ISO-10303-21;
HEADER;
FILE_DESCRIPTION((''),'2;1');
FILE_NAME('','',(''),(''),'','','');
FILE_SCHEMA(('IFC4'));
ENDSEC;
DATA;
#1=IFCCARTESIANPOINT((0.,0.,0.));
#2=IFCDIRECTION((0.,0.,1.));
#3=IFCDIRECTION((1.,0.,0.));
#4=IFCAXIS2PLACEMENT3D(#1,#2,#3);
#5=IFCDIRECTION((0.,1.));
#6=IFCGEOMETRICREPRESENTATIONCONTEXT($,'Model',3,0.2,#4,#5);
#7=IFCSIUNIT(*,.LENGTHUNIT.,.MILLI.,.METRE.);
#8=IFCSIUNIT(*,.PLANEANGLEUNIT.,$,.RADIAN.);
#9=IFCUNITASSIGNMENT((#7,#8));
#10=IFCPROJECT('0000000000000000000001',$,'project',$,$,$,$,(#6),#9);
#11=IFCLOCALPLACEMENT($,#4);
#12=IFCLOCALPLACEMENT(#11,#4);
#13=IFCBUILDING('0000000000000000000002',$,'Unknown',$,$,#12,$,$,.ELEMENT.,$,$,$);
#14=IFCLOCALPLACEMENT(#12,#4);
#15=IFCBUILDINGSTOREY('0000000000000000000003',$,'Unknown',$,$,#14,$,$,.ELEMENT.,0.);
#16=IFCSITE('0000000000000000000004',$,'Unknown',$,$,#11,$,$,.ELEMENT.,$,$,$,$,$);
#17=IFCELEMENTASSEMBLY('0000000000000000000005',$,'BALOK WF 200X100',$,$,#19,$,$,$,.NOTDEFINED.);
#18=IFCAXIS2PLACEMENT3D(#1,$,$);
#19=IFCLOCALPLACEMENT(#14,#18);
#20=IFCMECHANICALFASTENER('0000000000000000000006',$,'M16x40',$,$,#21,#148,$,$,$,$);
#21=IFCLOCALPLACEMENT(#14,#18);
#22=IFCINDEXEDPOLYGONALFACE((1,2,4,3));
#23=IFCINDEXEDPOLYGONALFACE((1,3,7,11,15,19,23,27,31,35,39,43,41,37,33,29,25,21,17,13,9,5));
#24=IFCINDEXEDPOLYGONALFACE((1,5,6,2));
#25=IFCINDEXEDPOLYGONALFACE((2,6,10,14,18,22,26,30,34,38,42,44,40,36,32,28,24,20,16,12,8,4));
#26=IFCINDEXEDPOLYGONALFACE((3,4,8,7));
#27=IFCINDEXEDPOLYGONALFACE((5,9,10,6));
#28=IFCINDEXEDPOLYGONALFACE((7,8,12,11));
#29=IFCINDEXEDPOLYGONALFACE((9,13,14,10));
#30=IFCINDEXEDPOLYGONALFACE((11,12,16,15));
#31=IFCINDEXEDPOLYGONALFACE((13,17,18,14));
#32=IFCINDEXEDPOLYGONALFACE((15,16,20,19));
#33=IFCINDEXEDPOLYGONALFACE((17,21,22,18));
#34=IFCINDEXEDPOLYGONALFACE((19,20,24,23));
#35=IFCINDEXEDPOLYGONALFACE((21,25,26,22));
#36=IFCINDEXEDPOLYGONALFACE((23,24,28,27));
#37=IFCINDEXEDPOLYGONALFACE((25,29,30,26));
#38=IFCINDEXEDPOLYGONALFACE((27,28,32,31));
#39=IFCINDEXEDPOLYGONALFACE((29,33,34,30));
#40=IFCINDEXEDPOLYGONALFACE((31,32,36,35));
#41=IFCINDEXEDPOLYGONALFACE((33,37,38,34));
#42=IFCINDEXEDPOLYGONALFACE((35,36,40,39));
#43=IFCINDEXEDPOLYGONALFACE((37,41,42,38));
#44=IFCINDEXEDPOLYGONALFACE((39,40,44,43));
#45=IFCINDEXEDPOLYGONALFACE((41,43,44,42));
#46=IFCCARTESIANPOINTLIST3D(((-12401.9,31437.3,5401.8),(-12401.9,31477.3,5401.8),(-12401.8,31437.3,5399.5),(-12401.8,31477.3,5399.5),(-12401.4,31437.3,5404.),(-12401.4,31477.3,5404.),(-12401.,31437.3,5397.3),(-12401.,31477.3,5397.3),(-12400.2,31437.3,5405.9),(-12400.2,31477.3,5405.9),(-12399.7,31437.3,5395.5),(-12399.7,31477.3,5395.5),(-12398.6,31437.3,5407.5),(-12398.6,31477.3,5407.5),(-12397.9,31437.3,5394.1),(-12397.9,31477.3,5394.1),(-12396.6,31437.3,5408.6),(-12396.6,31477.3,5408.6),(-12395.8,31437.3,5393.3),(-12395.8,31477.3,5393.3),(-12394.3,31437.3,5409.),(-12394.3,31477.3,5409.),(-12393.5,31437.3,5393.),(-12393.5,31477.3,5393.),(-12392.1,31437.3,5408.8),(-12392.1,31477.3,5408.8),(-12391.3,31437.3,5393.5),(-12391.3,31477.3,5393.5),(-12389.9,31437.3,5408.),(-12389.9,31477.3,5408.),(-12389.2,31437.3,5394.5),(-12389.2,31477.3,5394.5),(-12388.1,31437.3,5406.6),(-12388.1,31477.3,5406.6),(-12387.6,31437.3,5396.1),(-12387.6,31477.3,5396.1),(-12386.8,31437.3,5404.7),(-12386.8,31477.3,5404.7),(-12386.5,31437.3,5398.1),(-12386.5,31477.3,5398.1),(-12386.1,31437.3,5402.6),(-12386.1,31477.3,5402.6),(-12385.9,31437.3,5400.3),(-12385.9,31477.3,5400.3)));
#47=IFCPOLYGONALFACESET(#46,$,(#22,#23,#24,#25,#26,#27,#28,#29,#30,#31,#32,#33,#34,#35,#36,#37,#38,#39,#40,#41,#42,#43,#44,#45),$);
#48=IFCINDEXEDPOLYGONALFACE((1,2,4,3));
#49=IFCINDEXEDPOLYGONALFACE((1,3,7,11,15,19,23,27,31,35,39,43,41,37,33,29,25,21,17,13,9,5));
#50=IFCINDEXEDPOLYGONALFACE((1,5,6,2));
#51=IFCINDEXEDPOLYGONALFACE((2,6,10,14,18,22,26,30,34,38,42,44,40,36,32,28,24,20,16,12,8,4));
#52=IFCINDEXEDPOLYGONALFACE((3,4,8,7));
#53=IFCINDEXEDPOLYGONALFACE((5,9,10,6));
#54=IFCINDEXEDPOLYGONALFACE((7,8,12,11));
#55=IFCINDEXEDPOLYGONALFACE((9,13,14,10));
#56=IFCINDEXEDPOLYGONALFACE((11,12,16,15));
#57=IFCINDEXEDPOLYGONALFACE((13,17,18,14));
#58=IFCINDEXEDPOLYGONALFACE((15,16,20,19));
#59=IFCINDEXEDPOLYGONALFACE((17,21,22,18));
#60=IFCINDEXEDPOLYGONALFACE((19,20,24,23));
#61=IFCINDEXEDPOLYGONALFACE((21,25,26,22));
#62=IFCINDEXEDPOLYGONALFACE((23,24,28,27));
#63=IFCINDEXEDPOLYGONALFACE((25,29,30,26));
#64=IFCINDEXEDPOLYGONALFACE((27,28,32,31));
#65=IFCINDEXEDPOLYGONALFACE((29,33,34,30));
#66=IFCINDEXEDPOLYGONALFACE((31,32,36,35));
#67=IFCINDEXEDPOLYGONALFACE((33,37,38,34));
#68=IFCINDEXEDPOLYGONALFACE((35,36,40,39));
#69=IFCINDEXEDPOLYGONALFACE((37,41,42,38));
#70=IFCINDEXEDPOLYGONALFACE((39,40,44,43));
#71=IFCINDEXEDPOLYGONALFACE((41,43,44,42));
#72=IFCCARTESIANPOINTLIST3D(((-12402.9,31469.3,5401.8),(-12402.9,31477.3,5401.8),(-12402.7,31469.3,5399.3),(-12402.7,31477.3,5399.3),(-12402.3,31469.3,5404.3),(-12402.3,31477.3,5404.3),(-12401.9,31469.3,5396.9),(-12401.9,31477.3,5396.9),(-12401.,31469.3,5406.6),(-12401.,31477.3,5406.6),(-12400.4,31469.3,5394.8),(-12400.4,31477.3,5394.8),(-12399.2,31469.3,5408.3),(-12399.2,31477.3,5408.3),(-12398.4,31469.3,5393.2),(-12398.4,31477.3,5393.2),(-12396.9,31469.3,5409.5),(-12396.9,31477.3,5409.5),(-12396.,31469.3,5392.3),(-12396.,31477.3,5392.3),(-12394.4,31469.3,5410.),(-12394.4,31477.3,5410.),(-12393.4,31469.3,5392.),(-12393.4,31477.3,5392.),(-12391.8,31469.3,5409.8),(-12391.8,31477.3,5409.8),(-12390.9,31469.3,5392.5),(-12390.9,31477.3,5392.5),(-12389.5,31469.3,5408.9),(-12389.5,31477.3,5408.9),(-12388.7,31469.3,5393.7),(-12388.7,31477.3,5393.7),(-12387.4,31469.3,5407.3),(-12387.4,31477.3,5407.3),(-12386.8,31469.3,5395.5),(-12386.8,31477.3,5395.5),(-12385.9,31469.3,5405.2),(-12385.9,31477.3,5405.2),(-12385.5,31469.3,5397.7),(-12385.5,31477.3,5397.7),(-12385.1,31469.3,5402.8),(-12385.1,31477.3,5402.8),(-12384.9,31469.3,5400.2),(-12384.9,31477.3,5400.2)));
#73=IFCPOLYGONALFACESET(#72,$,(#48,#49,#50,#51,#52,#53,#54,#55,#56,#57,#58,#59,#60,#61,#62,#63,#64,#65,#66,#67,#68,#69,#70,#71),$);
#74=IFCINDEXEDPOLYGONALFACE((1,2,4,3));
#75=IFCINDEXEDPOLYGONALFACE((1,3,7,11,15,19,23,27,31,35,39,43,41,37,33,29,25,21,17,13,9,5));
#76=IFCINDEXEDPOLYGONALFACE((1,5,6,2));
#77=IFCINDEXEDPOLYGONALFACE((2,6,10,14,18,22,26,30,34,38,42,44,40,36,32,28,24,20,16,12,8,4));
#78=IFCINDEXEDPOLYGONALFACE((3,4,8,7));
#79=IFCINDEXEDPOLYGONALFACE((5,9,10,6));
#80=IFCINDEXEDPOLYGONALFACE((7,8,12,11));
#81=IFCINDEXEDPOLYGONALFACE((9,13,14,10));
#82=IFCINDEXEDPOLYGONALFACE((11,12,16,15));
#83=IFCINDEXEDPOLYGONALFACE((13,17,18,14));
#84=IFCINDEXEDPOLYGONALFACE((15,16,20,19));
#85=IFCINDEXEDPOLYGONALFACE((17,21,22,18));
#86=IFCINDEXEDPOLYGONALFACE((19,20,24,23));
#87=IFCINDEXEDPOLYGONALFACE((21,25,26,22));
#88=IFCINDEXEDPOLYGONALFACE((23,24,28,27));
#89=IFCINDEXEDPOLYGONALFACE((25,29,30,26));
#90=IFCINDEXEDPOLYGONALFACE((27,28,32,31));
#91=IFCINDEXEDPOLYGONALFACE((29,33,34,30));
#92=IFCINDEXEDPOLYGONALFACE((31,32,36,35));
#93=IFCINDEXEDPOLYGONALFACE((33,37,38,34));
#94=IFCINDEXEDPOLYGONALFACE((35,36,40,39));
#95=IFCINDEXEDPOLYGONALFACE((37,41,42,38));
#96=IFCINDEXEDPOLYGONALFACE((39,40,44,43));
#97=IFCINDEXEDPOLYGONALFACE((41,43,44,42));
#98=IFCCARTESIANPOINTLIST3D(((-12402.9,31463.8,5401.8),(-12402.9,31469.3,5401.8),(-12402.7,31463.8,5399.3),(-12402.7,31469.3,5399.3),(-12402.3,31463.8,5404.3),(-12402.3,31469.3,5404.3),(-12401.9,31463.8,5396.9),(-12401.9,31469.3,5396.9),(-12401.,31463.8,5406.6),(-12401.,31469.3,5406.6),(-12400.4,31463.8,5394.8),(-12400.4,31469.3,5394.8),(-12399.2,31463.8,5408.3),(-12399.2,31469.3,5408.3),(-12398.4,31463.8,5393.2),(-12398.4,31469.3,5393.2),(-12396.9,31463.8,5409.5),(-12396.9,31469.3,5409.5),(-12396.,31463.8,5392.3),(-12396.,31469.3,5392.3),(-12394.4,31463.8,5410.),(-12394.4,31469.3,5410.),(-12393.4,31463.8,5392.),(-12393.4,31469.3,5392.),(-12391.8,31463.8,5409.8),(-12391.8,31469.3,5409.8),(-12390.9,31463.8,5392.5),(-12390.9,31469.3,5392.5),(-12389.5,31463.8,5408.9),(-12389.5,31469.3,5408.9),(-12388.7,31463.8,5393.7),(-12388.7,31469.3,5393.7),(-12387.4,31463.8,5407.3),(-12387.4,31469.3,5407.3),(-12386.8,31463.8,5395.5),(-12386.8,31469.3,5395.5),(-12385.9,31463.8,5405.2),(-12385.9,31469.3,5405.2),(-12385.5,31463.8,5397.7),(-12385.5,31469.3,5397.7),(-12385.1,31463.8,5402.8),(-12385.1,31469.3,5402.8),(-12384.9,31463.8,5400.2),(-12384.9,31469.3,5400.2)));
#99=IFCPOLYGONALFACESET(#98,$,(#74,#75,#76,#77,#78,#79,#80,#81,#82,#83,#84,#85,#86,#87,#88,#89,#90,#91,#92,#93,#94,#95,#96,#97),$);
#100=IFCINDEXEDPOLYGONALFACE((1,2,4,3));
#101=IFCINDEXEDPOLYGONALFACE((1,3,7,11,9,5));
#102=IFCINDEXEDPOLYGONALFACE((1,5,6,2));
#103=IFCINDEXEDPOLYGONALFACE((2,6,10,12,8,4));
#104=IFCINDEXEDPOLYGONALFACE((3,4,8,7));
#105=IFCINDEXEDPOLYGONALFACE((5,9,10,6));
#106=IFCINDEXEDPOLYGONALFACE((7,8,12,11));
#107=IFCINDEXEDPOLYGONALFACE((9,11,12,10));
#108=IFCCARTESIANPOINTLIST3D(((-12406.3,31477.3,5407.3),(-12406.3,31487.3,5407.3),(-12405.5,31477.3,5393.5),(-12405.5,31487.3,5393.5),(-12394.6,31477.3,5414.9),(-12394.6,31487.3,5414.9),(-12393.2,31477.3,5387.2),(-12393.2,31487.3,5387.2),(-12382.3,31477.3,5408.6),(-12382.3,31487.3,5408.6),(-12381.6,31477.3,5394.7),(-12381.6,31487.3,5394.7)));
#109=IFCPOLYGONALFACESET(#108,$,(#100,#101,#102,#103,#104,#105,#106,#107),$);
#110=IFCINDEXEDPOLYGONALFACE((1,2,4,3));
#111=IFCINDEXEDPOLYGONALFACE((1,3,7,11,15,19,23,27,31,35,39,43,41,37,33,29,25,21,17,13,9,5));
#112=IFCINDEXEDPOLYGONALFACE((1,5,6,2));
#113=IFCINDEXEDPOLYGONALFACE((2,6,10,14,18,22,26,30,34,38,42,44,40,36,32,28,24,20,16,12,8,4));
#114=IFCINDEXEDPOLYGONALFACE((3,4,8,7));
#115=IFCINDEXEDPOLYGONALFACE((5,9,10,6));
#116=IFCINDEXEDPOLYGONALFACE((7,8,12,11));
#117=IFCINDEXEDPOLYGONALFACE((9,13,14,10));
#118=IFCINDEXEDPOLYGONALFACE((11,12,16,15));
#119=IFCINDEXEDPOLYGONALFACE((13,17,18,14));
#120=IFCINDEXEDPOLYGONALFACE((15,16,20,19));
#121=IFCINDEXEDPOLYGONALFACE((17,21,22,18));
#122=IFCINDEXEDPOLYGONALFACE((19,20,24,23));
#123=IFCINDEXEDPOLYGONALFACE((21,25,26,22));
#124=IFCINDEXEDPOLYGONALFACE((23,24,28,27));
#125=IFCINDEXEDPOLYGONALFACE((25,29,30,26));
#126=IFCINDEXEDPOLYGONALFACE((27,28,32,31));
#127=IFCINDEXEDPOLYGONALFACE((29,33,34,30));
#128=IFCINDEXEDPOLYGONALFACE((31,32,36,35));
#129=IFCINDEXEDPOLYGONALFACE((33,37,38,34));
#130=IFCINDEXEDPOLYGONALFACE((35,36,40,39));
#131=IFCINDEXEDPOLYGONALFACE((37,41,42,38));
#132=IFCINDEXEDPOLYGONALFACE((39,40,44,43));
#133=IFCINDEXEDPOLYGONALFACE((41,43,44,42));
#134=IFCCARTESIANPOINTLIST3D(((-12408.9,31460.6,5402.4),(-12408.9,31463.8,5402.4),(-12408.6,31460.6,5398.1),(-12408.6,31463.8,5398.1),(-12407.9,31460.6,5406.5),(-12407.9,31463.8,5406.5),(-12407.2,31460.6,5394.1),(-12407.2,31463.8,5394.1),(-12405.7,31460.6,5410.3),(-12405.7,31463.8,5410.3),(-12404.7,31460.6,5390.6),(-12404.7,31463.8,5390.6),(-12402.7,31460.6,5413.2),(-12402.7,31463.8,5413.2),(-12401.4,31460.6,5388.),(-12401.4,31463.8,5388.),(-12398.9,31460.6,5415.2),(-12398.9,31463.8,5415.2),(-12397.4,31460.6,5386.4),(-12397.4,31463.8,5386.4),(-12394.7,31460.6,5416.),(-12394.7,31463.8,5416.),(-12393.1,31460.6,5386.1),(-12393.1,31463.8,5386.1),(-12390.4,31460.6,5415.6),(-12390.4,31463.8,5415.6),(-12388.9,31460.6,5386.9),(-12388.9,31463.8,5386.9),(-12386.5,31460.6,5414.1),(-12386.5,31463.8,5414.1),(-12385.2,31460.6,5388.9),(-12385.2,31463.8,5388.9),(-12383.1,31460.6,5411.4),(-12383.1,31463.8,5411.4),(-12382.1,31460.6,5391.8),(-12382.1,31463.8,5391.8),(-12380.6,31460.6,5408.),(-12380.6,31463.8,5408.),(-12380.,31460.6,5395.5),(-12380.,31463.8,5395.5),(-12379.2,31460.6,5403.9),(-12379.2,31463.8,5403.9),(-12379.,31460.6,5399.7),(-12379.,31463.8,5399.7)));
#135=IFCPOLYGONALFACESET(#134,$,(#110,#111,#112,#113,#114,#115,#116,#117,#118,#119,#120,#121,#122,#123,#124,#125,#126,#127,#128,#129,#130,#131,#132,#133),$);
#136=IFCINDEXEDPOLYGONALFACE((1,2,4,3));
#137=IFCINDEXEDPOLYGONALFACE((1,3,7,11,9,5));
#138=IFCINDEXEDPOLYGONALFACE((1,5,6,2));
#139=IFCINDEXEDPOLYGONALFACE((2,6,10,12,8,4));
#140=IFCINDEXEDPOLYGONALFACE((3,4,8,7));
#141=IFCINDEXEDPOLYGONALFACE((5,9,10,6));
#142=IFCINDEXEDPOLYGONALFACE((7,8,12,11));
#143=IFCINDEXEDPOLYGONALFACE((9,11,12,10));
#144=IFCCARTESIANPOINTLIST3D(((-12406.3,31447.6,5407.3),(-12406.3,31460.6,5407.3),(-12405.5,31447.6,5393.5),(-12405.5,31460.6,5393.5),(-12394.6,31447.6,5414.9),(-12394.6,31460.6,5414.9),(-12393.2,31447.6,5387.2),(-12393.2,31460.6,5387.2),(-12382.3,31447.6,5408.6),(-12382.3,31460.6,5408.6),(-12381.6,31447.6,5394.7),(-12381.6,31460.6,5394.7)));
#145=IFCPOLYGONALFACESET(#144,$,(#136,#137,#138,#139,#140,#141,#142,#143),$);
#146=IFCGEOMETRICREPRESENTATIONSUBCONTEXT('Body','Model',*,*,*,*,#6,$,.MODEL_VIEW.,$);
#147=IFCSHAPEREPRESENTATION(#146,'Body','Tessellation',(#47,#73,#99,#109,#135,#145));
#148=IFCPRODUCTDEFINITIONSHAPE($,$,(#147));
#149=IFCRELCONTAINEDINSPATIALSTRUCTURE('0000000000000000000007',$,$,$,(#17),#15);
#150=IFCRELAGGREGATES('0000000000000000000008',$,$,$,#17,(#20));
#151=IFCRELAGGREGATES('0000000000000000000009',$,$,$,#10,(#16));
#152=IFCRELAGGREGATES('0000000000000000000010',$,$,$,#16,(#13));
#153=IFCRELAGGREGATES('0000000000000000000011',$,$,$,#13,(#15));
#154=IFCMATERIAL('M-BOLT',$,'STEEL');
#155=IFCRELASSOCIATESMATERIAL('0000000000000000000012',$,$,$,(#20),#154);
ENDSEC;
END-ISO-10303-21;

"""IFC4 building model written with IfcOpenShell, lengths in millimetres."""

from ifc_helpers import new_model, si_unit, direction, frame, origin_with_axes, place, context, subcontext, project, spatial, line, arc, indexed_curve, outline, extrude, source, transform, mapped, material, element, aggregate, save


model = new_model("IFC4")

# Units and contexts
model_context = context("Model", 3, precision=0.2, world=origin_with_axes(), true_north=direction((0.0, 1.0)))
body_context = subcontext(model_context, "Body", "Model", "MODEL_VIEW")
ifc_project = project(units=[si_unit("LENGTHUNIT", "METRE", prefix="MILLI"), si_unit("PLANEANGLEUNIT", "RADIAN")], contexts=[model_context])

# Site, building, storey
site_placement = place(None, origin_with_axes())
site = spatial("IfcSite", under=ifc_project, at=site_placement, Name="Unknown", CompositionType="ELEMENT")
building_placement = place(site_placement, origin_with_axes())
building = spatial("IfcBuilding", under=site, at=building_placement, Name="Unknown", CompositionType="ELEMENT")
storey_placement = place(building_placement, origin_with_axes())
storey = spatial("IfcBuildingStorey", under=building, at=storey_placement, Name="Unknown", CompositionType="ELEMENT", Elevation=0.0)

# Element assembly
assembly_1_placement = place(storey_placement, frame((-7044.1, 31466.5, 5721.5), z_axis=(0.0, 1.0, 0.0), x_axis=(-0.99863, 0.0, -0.052336)))
assembly_1 = element("IfcElementAssembly", 1, at=assembly_1_placement, inside=storey, Name="BALOK WF 200X100", PredefinedType="NOTDEFINED")

# Mechanical fastener
ifc_material_1 = material(Name="M-BOLT", Category="STEEL")
shared_shape_1 = source(origin_with_axes(), body_context, "Body", "SweptSolid", [
    extrude(outline(indexed_curve([(8.0, 0.0), (0.0, 8.0), (-8.0, 0.0), (0.0, -8.0)], segments=[arc(1, 2, 3), arc(3, 4, 1)])), frame((0.0, 0.0, 0.0), z_axis=(0.0, 0.0, -1.0), x_axis=(0.0, 1.0, 0.0)), (0.0, 0.0, 1.0), 40.0),
    extrude(outline(indexed_curve([(9.0, 0.0), (0.0, 9.0), (-9.0, 0.0), (0.0, -9.0)], segments=[arc(1, 2, 3), arc(3, 4, 1)])), frame((0.0, 0.0, 0.0), z_axis=(0.0, 0.0, -1.0), x_axis=(0.0, 1.0, 0.0)), (0.0, 0.0, 1.0), 8.0),
    extrude(outline(indexed_curve([(9.0, 0.0), (0.0, 9.0), (-9.0, 0.0), (0.0, -9.0)], segments=[arc(1, 2, 3), arc(3, 4, 1)])), frame((0.0, 0.0, -8.0), z_axis=(0.0, 0.0, -1.0), x_axis=(0.0, 1.0, 0.0)), (0.0, 0.0, 1.0), 5.5),
    extrude(outline(indexed_curve([(13.9, 0.0), (6.9, 12.0), (-6.9, 12.0), (-13.9, 0.0), (-6.9, -12.0), (6.9, -12.0)], segments=[line(1, 2, 3, 4, 5, 6, 1)])), frame((0.0, 0.0, 10.0), z_axis=(0.0, 0.0, -1.0), x_axis=(0.0, 1.0, 0.0)), (0.0, 0.0, 1.0), 10.0),
    extrude(outline(indexed_curve([(15.0, 0.0), (0.0, 15.0), (-15.0, 0.0), (0.0, -15.0)], segments=[arc(1, 2, 3), arc(3, 4, 1)])), frame((0.0, 0.0, -13.5), z_axis=(0.0, 0.0, -1.0), x_axis=(0.0, 1.0, 0.0)), (0.0, 0.0, 1.0), 3.2),
    extrude(outline(indexed_curve([(13.9, 0.0), (6.9, 12.0), (-6.9, 12.0), (-13.9, 0.0), (-6.9, -12.0), (6.9, -12.0)], segments=[line(1, 2, 3, 4, 5, 6, 1)])), frame((0.0, 0.0, -16.7), z_axis=(0.0, 0.0, -1.0), x_axis=(0.0, 1.0, 0.0)), (0.0, 0.0, 1.0), 13.0),
])
mechanical_fastener_1_placement = place(assembly_1_placement, frame((5359.2, -40.0, 10.7), z_axis=(-0.000004, 0.0, 1.0), x_axis=(-1.0, 0.0, -0.000004)))
mechanical_fastener_1 = element("IfcMechanicalFastener", 2, at=mechanical_fastener_1_placement, material=ifc_material_1, Name="M16x40", context=body_context, shape_type="MappedRepresentation", body=[
    mapped(shared_shape_1, transform((0.0, 0.0, 0.0))),
])

aggregate(assembly_1, [mechanical_fastener_1])

save(model, "model.ifc")
